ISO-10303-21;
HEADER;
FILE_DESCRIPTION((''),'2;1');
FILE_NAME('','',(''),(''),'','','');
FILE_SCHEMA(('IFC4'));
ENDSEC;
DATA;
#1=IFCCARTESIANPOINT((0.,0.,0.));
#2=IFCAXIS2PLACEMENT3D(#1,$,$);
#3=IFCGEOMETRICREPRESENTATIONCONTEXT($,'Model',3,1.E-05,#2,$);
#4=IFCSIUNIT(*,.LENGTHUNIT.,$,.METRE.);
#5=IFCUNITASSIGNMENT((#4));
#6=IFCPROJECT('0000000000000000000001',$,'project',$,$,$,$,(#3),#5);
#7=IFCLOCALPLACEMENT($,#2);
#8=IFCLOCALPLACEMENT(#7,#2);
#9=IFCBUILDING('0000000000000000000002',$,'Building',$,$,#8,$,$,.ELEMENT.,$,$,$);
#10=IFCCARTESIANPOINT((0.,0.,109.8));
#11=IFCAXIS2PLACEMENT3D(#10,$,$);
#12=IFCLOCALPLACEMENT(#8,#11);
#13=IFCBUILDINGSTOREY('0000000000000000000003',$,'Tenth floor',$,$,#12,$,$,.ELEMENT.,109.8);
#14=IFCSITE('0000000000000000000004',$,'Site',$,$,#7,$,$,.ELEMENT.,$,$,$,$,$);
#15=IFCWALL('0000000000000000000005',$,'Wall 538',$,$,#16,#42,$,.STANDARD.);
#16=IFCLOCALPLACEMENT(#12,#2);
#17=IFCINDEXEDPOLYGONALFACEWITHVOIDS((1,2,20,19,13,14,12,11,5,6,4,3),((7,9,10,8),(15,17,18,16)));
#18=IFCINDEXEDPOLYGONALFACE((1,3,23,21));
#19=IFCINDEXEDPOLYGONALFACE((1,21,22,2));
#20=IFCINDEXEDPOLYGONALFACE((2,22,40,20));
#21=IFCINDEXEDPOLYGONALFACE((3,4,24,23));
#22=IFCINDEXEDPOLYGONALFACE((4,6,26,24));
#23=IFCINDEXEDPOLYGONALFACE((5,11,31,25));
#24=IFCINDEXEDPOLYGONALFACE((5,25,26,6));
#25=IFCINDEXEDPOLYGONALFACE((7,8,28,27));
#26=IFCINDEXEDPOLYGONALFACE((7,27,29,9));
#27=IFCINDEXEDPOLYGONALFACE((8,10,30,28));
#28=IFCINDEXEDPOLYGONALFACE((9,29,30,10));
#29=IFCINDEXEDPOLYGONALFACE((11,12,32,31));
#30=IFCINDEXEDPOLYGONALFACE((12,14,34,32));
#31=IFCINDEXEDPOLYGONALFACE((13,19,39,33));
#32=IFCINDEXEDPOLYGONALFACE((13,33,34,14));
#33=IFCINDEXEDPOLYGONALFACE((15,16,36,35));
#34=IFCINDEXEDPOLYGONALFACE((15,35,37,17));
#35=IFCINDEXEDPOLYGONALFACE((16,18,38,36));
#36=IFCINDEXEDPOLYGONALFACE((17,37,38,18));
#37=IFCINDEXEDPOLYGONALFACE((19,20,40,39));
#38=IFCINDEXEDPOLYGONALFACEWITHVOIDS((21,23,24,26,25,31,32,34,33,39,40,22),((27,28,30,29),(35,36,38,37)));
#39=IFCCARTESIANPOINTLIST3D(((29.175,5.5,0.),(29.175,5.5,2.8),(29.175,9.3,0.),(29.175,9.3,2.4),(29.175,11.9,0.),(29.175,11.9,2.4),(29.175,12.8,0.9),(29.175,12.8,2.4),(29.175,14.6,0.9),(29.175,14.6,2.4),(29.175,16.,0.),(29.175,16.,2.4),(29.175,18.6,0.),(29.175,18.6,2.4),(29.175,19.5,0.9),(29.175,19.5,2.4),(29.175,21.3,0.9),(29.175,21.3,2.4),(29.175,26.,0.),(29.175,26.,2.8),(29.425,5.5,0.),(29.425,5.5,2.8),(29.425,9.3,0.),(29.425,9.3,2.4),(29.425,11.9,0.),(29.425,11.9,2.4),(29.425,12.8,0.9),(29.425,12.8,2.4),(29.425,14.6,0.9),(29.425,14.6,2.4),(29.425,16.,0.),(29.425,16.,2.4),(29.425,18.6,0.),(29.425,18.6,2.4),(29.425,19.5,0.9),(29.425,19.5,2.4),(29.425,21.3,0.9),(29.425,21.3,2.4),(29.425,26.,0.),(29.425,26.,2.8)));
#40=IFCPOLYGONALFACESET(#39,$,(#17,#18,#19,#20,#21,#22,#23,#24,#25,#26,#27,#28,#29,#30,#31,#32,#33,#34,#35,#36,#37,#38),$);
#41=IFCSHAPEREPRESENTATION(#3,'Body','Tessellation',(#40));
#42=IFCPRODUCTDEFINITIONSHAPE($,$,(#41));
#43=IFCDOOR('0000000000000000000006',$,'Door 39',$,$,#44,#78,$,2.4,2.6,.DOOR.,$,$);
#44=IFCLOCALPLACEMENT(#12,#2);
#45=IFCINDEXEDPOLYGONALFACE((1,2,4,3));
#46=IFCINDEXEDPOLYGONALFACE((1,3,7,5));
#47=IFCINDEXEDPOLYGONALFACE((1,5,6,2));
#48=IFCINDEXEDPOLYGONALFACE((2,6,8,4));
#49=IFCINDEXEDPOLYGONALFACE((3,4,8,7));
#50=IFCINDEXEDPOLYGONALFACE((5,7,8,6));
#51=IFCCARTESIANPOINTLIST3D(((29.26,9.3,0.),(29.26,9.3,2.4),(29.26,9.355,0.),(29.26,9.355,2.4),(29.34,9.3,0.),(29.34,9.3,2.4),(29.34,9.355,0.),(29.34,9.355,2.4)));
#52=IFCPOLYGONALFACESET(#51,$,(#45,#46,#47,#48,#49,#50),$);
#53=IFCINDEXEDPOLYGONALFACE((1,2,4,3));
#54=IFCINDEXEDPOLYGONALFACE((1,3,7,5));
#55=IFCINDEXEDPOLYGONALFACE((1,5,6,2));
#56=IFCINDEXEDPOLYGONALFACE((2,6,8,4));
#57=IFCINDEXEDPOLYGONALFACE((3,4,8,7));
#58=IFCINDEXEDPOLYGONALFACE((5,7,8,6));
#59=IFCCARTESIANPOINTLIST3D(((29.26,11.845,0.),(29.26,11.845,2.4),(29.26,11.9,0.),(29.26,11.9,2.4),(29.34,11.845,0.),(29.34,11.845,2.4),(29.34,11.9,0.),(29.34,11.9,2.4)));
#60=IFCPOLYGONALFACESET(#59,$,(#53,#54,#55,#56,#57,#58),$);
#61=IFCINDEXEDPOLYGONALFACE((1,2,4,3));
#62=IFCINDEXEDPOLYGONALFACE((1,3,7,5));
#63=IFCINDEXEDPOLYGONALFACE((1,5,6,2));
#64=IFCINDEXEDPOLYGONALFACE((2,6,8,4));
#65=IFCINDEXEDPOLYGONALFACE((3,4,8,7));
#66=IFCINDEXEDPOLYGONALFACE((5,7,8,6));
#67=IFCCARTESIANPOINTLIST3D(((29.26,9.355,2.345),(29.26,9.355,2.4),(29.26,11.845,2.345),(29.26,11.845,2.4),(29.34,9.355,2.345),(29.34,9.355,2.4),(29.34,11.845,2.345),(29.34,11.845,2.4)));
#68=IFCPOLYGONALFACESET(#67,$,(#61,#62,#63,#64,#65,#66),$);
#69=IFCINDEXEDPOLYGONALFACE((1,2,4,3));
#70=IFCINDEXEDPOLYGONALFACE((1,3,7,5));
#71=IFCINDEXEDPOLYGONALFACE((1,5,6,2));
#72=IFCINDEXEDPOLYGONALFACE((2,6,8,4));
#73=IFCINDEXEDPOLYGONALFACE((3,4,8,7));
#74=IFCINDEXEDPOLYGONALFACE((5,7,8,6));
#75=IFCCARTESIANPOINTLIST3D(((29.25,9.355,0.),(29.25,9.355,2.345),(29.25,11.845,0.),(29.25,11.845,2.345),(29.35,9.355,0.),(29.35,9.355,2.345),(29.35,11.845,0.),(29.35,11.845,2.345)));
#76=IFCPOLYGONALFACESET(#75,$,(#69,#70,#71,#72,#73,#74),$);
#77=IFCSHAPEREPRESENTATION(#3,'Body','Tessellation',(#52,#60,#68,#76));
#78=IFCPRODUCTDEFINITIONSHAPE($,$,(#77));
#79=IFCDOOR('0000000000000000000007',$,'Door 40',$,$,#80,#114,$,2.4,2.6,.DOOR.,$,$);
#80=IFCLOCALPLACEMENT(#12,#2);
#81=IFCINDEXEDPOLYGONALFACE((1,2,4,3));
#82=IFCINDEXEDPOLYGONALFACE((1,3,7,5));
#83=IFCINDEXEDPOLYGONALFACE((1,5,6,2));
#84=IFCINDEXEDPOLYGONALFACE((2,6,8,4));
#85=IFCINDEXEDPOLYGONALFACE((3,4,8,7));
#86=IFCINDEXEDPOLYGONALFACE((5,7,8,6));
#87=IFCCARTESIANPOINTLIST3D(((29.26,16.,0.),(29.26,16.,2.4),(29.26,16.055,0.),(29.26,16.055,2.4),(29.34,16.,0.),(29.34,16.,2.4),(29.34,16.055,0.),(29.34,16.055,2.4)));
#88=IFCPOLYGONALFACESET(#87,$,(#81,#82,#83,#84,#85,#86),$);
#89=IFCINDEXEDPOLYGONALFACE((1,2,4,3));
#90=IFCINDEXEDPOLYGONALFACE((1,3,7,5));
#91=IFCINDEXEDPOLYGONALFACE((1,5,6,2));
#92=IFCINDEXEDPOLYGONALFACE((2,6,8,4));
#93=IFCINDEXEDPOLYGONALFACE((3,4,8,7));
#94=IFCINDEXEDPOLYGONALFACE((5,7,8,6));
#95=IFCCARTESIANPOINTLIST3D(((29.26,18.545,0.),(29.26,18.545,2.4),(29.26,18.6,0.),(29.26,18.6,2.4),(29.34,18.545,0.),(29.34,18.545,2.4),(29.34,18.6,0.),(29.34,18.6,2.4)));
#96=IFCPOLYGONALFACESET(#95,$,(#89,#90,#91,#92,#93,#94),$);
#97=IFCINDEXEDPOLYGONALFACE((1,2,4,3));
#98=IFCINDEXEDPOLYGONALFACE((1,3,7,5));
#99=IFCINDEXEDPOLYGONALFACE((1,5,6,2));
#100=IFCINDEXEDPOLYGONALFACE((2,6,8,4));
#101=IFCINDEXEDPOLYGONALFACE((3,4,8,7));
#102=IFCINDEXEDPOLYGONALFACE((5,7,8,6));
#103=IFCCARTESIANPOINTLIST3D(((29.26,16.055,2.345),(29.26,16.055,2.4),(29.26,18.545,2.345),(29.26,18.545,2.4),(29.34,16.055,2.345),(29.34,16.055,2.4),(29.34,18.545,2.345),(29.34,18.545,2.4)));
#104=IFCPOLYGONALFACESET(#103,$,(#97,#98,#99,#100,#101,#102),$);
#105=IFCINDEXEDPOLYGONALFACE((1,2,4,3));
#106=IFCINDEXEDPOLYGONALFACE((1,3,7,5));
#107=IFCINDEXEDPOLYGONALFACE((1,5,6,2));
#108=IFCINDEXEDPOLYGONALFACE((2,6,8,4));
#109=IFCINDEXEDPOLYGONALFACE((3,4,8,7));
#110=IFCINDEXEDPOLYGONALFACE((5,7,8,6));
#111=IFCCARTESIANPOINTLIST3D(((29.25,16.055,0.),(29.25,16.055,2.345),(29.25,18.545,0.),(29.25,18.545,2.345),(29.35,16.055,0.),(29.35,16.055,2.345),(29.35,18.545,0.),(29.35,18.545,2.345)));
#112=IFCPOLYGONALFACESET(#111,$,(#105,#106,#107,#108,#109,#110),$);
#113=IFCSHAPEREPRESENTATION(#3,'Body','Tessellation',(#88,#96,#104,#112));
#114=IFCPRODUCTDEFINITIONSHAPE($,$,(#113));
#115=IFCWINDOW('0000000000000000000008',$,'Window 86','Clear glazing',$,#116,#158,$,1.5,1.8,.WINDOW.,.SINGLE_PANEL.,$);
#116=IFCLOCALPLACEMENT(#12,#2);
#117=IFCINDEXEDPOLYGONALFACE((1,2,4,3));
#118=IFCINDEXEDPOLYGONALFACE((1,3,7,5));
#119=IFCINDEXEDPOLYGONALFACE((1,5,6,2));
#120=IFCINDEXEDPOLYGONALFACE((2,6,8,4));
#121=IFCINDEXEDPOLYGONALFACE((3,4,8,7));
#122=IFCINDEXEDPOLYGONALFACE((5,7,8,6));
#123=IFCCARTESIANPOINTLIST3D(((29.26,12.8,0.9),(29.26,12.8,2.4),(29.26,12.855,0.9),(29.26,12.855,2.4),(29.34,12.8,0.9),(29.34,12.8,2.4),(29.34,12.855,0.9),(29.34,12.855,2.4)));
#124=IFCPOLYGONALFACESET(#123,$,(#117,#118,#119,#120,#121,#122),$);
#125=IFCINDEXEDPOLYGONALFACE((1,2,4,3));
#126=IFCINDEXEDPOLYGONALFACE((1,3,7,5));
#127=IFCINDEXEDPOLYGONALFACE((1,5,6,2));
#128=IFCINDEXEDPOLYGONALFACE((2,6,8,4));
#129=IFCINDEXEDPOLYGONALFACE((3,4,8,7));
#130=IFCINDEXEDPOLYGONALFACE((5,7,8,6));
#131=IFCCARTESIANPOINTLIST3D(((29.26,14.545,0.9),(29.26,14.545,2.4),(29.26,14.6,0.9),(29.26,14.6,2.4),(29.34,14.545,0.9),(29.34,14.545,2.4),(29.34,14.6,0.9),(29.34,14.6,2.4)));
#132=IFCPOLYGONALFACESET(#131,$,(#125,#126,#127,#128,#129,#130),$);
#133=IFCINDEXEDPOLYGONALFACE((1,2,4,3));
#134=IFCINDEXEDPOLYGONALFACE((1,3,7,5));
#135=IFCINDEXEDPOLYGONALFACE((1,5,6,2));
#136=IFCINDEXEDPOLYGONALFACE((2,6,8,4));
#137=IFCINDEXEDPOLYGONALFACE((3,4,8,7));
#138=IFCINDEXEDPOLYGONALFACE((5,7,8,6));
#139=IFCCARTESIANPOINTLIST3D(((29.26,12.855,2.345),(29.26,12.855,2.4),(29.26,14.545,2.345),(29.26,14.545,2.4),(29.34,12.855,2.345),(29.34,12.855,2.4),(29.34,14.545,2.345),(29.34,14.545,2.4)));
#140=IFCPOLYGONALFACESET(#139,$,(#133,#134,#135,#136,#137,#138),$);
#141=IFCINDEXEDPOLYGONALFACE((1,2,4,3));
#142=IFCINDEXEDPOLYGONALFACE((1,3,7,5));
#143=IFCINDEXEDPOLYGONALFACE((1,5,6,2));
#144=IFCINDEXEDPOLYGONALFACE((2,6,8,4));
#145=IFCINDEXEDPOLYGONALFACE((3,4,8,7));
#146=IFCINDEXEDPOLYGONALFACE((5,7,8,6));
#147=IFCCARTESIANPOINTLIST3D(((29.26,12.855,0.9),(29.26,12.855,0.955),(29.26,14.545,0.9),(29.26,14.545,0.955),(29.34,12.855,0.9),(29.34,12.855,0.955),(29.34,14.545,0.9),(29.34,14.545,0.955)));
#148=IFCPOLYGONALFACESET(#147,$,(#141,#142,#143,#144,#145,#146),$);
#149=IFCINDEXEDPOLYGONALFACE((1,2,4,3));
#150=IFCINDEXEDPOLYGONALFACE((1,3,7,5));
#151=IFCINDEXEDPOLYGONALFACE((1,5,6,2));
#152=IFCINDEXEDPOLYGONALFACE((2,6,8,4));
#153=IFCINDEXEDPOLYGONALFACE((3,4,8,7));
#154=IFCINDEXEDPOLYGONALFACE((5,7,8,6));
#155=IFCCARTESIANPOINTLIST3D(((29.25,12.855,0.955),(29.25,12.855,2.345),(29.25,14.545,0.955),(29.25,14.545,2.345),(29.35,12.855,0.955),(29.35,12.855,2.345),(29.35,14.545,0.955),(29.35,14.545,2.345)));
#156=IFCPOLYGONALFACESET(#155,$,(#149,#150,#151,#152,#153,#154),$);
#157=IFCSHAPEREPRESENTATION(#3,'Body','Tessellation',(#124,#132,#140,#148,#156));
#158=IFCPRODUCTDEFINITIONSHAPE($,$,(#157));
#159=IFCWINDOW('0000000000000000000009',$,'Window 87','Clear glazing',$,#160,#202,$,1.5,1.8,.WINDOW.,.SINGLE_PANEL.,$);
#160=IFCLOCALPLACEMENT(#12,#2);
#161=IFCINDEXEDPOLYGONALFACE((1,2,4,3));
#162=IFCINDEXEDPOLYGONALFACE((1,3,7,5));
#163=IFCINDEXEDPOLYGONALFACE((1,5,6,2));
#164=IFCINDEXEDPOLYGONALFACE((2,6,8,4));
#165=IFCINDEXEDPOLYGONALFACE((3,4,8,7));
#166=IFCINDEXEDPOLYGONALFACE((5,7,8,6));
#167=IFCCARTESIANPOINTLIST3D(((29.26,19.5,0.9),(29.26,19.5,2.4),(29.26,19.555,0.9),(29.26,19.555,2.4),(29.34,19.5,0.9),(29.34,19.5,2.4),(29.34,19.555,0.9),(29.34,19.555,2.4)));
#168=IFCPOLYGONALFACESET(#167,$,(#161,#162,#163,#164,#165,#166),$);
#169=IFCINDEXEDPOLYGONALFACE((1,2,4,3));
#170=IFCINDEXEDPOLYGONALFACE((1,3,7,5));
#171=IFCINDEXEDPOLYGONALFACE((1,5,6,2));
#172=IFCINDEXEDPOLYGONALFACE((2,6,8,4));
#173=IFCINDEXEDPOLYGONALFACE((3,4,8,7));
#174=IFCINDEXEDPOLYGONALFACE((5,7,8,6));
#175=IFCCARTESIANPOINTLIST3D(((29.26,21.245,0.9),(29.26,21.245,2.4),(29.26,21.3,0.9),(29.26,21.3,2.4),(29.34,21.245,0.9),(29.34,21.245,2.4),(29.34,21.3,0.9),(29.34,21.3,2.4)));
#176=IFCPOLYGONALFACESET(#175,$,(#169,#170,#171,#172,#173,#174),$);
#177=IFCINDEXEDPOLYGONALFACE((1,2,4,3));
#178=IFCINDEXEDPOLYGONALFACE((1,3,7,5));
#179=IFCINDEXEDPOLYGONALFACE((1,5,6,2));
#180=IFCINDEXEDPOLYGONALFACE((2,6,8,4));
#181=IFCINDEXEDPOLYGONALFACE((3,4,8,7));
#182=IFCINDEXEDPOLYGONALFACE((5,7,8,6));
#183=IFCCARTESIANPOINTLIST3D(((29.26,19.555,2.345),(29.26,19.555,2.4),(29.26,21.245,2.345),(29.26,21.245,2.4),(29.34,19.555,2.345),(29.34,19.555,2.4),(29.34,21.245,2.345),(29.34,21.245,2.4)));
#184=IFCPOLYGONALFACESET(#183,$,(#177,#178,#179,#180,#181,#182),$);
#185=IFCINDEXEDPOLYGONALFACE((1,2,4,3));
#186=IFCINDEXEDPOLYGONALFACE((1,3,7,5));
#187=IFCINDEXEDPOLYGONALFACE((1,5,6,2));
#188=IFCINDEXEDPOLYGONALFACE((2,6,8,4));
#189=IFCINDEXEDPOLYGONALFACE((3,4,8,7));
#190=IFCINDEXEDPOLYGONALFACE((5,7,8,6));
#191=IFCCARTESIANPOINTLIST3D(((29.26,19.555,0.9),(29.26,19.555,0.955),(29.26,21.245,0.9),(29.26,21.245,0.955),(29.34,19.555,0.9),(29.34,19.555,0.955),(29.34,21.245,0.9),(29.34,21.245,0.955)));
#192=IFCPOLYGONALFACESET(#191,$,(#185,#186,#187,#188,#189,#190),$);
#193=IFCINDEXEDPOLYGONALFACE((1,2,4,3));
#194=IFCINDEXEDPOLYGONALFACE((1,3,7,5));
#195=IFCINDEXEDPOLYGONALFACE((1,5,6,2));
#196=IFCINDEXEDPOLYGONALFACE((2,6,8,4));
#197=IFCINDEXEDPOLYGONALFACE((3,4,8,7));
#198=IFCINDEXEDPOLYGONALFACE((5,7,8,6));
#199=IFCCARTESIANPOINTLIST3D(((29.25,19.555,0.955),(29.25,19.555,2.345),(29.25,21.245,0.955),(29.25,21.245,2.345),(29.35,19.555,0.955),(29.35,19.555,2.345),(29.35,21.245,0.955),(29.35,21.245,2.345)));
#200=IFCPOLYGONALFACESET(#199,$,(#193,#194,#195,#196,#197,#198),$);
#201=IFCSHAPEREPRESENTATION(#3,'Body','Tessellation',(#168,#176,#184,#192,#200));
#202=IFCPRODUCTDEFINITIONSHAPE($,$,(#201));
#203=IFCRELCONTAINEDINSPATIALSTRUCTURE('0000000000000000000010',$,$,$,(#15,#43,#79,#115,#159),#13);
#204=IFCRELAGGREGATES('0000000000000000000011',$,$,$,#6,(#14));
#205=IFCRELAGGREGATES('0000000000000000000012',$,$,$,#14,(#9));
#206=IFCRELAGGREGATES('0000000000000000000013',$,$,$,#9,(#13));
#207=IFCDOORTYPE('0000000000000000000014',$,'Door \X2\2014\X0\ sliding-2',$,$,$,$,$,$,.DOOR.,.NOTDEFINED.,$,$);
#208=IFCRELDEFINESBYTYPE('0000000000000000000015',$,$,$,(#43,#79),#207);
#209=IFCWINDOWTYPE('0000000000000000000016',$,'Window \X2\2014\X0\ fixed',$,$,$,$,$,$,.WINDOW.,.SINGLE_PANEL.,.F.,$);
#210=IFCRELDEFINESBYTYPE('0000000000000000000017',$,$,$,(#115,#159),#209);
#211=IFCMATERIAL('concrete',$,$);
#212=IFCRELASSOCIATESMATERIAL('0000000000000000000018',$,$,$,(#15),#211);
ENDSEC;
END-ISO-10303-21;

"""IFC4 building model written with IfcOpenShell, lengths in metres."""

from ifc_helpers import new_model, si_unit, frame, frame_2d, origin, place, context, project, spatial, rectangle, extrude, material, type_object, element, fill, save


model = new_model("IFC4")

# Units and contexts
model_context = context("Model", 3, precision=1e-05, world=origin())
ifc_project = project(units=[si_unit("LENGTHUNIT", "METRE")], contexts=[model_context])

# Site, building, storey
site_placement = place(None, origin())
site = spatial("IfcSite", under=ifc_project, at=site_placement, Name="Site", CompositionType="ELEMENT")
building_placement = place(site_placement, origin())
building = spatial("IfcBuilding", under=site, at=building_placement, Name="Building", CompositionType="ELEMENT")
storey_placement = place(building_placement, frame((0.0, 0.0, 109.8)))
storey = spatial("IfcBuildingStorey", under=building, at=storey_placement, Name="Tenth floor", CompositionType="ELEMENT", Elevation=109.8)

# Shared definitions
ifc_material = material(Name="concrete")

# Wall, openings, doors, windows
wall_1_placement = place(storey_placement, frame((29.3, 5.5, 0.0), z_axis=(0.0, 0.0, 1.0), x_axis=(0.0, 1.0, 0.0)))
wall_1 = element("IfcWall", 1, at=wall_1_placement, inside=storey, material=ifc_material, Name="Wall 538", PredefinedType="STANDARD", context=model_context, shape_type="SweptSolid", body=[
    extrude(rectangle(XDim=20.5, YDim=0.25, at=frame_2d((10.25, 0.0))), origin(), (0.0, 0.0, 1.0), 2.8),
])
opening_1_placement = place(storey_placement, frame((29.3, 9.3, 0.0), z_axis=(0.0, 0.0, 1.0), x_axis=(0.0, 1.0, 0.0)))
opening_1 = element("IfcOpeningElement", 2, at=opening_1_placement, cuts=wall_1, PredefinedType="OPENING", context=model_context, shape_type="SweptSolid", body=[
    extrude(rectangle(XDim=2.6, YDim=0.31, at=frame_2d((1.3, 0.0))), origin(), (0.0, 0.0, 1.0), 2.4),
])
opening_2_placement = place(storey_placement, frame((29.3, 12.8, 0.9), z_axis=(0.0, 0.0, 1.0), x_axis=(0.0, 1.0, 0.0)))
opening_2 = element("IfcOpeningElement", 3, at=opening_2_placement, cuts=wall_1, PredefinedType="OPENING", context=model_context, shape_type="SweptSolid", body=[
    extrude(rectangle(XDim=1.8, YDim=0.31, at=frame_2d((0.9, 0.0))), origin(), (0.0, 0.0, 1.0), 1.5),
])
opening_3_placement = place(storey_placement, frame((29.3, 16.0, 0.0), z_axis=(0.0, 0.0, 1.0), x_axis=(0.0, 1.0, 0.0)))
opening_3 = element("IfcOpeningElement", 4, at=opening_3_placement, cuts=wall_1, PredefinedType="OPENING", context=model_context, shape_type="SweptSolid", body=[
    extrude(rectangle(XDim=2.6, YDim=0.31, at=frame_2d((1.3, 0.0))), origin(), (0.0, 0.0, 1.0), 2.4),
])
opening_4_placement = place(storey_placement, frame((29.3, 19.5, 0.9), z_axis=(0.0, 0.0, 1.0), x_axis=(0.0, 1.0, 0.0)))
opening_4 = element("IfcOpeningElement", 5, at=opening_4_placement, cuts=wall_1, PredefinedType="OPENING", context=model_context, shape_type="SweptSolid", body=[
    extrude(rectangle(XDim=1.8, YDim=0.31, at=frame_2d((0.9, 0.0))), origin(), (0.0, 0.0, 1.0), 1.5),
])
door_type = type_object("IfcDoorType", Name="Door — sliding-2", PredefinedType="DOOR")
door_1_placement = place(storey_placement, frame((29.3, 9.3, 0.0), z_axis=(0.0, 0.0, 1.0), x_axis=(0.0, 1.0, 0.0)))
door_1 = element("IfcDoor", 6, at=door_1_placement, inside=storey, type_object=door_type, Name="Door 39", OverallHeight=2.4, OverallWidth=2.6, PredefinedType="DOOR", context=model_context, shape_type="SweptSolid", body=[
    extrude(rectangle(XDim=0.055, YDim=0.08, at=frame_2d((0.0275, 0.0))), origin(), (0.0, 0.0, 1.0), 2.4),
    extrude(rectangle(XDim=0.055, YDim=0.08, at=frame_2d((2.5725, 0.0))), origin(), (0.0, 0.0, 1.0), 2.4),
    extrude(rectangle(XDim=2.49, YDim=0.08, at=frame_2d((1.3, 0.0))), frame((0.0, 0.0, 2.345)), (0.0, 0.0, 1.0), 0.055),
    extrude(rectangle(XDim=2.49, YDim=0.1, at=frame_2d((1.3, 0.0))), origin(), (0.0, 0.0, 1.0), 2.345),
])
fill(opening_1, door_1)
door_2_placement = place(storey_placement, frame((29.3, 16.0, 0.0), z_axis=(0.0, 0.0, 1.0), x_axis=(0.0, 1.0, 0.0)))
door_2 = element("IfcDoor", 7, at=door_2_placement, inside=storey, type_object=door_type, Name="Door 40", OverallHeight=2.4, OverallWidth=2.6, PredefinedType="DOOR", context=model_context, shape_type="SweptSolid", body=[
    extrude(rectangle(XDim=0.055, YDim=0.08, at=frame_2d((0.0275, 0.0))), origin(), (0.0, 0.0, 1.0), 2.4),
    extrude(rectangle(XDim=0.055, YDim=0.08, at=frame_2d((2.5725, 0.0))), origin(), (0.0, 0.0, 1.0), 2.4),
    extrude(rectangle(XDim=2.49, YDim=0.08, at=frame_2d((1.3, 0.0))), frame((0.0, 0.0, 2.345)), (0.0, 0.0, 1.0), 0.055),
    extrude(rectangle(XDim=2.49, YDim=0.1, at=frame_2d((1.3, 0.0))), origin(), (0.0, 0.0, 1.0), 2.345),
])
fill(opening_3, door_2)
window_type = type_object("IfcWindowType", Name="Window — fixed", ParameterTakesPrecedence=False, PartitioningType="SINGLE_PANEL", PredefinedType="WINDOW")
window_1_placement = place(storey_placement, frame((29.3, 12.8, 0.9), z_axis=(0.0, 0.0, 1.0), x_axis=(0.0, 1.0, 0.0)))
window_1 = element("IfcWindow", 8, at=window_1_placement, inside=storey, type_object=window_type, Name="Window 86", Description="Clear glazing", OverallHeight=1.5, OverallWidth=1.8, PartitioningType="SINGLE_PANEL", PredefinedType="WINDOW", context=model_context, shape_type="SweptSolid", body=[
    extrude(rectangle(XDim=0.055, YDim=0.08, at=frame_2d((0.0275, 0.0))), origin(), (0.0, 0.0, 1.0), 1.5),
    extrude(rectangle(XDim=0.055, YDim=0.08, at=frame_2d((1.7725, 0.0))), origin(), (0.0, 0.0, 1.0), 1.5),
    extrude(rectangle(XDim=1.69, YDim=0.08, at=frame_2d((0.9, 0.0))), frame((0.0, 0.0, 1.445)), (0.0, 0.0, 1.0), 0.055),
    extrude(rectangle(XDim=1.69, YDim=0.08, at=frame_2d((0.9, 0.0))), origin(), (0.0, 0.0, 1.0), 0.055),
    extrude(rectangle(XDim=1.69, YDim=0.1, at=frame_2d((0.9, 0.0))), frame((0.0, 0.0, 0.055)), (0.0, 0.0, 1.0), 1.39),
])
fill(opening_2, window_1)
window_2_placement = place(storey_placement, frame((29.3, 19.5, 0.9), z_axis=(0.0, 0.0, 1.0), x_axis=(0.0, 1.0, 0.0)))
window_2 = element("IfcWindow", 9, at=window_2_placement, inside=storey, type_object=window_type, Name="Window 87", Description="Clear glazing", OverallHeight=1.5, OverallWidth=1.8, PartitioningType="SINGLE_PANEL", PredefinedType="WINDOW", context=model_context, shape_type="SweptSolid", body=[
    extrude(rectangle(XDim=0.055, YDim=0.08, at=frame_2d((0.0275, 0.0))), origin(), (0.0, 0.0, 1.0), 1.5),
    extrude(rectangle(XDim=0.055, YDim=0.08, at=frame_2d((1.7725, 0.0))), origin(), (0.0, 0.0, 1.0), 1.5),
    extrude(rectangle(XDim=1.69, YDim=0.08, at=frame_2d((0.9, 0.0))), frame((0.0, 0.0, 1.445)), (0.0, 0.0, 1.0), 0.055),
    extrude(rectangle(XDim=1.69, YDim=0.08, at=frame_2d((0.9, 0.0))), origin(), (0.0, 0.0, 1.0), 0.055),
    extrude(rectangle(XDim=1.69, YDim=0.1, at=frame_2d((0.9, 0.0))), frame((0.0, 0.0, 0.055)), (0.0, 0.0, 1.0), 1.39),
])
fill(opening_4, window_2)

save(model, "model.ifc")
